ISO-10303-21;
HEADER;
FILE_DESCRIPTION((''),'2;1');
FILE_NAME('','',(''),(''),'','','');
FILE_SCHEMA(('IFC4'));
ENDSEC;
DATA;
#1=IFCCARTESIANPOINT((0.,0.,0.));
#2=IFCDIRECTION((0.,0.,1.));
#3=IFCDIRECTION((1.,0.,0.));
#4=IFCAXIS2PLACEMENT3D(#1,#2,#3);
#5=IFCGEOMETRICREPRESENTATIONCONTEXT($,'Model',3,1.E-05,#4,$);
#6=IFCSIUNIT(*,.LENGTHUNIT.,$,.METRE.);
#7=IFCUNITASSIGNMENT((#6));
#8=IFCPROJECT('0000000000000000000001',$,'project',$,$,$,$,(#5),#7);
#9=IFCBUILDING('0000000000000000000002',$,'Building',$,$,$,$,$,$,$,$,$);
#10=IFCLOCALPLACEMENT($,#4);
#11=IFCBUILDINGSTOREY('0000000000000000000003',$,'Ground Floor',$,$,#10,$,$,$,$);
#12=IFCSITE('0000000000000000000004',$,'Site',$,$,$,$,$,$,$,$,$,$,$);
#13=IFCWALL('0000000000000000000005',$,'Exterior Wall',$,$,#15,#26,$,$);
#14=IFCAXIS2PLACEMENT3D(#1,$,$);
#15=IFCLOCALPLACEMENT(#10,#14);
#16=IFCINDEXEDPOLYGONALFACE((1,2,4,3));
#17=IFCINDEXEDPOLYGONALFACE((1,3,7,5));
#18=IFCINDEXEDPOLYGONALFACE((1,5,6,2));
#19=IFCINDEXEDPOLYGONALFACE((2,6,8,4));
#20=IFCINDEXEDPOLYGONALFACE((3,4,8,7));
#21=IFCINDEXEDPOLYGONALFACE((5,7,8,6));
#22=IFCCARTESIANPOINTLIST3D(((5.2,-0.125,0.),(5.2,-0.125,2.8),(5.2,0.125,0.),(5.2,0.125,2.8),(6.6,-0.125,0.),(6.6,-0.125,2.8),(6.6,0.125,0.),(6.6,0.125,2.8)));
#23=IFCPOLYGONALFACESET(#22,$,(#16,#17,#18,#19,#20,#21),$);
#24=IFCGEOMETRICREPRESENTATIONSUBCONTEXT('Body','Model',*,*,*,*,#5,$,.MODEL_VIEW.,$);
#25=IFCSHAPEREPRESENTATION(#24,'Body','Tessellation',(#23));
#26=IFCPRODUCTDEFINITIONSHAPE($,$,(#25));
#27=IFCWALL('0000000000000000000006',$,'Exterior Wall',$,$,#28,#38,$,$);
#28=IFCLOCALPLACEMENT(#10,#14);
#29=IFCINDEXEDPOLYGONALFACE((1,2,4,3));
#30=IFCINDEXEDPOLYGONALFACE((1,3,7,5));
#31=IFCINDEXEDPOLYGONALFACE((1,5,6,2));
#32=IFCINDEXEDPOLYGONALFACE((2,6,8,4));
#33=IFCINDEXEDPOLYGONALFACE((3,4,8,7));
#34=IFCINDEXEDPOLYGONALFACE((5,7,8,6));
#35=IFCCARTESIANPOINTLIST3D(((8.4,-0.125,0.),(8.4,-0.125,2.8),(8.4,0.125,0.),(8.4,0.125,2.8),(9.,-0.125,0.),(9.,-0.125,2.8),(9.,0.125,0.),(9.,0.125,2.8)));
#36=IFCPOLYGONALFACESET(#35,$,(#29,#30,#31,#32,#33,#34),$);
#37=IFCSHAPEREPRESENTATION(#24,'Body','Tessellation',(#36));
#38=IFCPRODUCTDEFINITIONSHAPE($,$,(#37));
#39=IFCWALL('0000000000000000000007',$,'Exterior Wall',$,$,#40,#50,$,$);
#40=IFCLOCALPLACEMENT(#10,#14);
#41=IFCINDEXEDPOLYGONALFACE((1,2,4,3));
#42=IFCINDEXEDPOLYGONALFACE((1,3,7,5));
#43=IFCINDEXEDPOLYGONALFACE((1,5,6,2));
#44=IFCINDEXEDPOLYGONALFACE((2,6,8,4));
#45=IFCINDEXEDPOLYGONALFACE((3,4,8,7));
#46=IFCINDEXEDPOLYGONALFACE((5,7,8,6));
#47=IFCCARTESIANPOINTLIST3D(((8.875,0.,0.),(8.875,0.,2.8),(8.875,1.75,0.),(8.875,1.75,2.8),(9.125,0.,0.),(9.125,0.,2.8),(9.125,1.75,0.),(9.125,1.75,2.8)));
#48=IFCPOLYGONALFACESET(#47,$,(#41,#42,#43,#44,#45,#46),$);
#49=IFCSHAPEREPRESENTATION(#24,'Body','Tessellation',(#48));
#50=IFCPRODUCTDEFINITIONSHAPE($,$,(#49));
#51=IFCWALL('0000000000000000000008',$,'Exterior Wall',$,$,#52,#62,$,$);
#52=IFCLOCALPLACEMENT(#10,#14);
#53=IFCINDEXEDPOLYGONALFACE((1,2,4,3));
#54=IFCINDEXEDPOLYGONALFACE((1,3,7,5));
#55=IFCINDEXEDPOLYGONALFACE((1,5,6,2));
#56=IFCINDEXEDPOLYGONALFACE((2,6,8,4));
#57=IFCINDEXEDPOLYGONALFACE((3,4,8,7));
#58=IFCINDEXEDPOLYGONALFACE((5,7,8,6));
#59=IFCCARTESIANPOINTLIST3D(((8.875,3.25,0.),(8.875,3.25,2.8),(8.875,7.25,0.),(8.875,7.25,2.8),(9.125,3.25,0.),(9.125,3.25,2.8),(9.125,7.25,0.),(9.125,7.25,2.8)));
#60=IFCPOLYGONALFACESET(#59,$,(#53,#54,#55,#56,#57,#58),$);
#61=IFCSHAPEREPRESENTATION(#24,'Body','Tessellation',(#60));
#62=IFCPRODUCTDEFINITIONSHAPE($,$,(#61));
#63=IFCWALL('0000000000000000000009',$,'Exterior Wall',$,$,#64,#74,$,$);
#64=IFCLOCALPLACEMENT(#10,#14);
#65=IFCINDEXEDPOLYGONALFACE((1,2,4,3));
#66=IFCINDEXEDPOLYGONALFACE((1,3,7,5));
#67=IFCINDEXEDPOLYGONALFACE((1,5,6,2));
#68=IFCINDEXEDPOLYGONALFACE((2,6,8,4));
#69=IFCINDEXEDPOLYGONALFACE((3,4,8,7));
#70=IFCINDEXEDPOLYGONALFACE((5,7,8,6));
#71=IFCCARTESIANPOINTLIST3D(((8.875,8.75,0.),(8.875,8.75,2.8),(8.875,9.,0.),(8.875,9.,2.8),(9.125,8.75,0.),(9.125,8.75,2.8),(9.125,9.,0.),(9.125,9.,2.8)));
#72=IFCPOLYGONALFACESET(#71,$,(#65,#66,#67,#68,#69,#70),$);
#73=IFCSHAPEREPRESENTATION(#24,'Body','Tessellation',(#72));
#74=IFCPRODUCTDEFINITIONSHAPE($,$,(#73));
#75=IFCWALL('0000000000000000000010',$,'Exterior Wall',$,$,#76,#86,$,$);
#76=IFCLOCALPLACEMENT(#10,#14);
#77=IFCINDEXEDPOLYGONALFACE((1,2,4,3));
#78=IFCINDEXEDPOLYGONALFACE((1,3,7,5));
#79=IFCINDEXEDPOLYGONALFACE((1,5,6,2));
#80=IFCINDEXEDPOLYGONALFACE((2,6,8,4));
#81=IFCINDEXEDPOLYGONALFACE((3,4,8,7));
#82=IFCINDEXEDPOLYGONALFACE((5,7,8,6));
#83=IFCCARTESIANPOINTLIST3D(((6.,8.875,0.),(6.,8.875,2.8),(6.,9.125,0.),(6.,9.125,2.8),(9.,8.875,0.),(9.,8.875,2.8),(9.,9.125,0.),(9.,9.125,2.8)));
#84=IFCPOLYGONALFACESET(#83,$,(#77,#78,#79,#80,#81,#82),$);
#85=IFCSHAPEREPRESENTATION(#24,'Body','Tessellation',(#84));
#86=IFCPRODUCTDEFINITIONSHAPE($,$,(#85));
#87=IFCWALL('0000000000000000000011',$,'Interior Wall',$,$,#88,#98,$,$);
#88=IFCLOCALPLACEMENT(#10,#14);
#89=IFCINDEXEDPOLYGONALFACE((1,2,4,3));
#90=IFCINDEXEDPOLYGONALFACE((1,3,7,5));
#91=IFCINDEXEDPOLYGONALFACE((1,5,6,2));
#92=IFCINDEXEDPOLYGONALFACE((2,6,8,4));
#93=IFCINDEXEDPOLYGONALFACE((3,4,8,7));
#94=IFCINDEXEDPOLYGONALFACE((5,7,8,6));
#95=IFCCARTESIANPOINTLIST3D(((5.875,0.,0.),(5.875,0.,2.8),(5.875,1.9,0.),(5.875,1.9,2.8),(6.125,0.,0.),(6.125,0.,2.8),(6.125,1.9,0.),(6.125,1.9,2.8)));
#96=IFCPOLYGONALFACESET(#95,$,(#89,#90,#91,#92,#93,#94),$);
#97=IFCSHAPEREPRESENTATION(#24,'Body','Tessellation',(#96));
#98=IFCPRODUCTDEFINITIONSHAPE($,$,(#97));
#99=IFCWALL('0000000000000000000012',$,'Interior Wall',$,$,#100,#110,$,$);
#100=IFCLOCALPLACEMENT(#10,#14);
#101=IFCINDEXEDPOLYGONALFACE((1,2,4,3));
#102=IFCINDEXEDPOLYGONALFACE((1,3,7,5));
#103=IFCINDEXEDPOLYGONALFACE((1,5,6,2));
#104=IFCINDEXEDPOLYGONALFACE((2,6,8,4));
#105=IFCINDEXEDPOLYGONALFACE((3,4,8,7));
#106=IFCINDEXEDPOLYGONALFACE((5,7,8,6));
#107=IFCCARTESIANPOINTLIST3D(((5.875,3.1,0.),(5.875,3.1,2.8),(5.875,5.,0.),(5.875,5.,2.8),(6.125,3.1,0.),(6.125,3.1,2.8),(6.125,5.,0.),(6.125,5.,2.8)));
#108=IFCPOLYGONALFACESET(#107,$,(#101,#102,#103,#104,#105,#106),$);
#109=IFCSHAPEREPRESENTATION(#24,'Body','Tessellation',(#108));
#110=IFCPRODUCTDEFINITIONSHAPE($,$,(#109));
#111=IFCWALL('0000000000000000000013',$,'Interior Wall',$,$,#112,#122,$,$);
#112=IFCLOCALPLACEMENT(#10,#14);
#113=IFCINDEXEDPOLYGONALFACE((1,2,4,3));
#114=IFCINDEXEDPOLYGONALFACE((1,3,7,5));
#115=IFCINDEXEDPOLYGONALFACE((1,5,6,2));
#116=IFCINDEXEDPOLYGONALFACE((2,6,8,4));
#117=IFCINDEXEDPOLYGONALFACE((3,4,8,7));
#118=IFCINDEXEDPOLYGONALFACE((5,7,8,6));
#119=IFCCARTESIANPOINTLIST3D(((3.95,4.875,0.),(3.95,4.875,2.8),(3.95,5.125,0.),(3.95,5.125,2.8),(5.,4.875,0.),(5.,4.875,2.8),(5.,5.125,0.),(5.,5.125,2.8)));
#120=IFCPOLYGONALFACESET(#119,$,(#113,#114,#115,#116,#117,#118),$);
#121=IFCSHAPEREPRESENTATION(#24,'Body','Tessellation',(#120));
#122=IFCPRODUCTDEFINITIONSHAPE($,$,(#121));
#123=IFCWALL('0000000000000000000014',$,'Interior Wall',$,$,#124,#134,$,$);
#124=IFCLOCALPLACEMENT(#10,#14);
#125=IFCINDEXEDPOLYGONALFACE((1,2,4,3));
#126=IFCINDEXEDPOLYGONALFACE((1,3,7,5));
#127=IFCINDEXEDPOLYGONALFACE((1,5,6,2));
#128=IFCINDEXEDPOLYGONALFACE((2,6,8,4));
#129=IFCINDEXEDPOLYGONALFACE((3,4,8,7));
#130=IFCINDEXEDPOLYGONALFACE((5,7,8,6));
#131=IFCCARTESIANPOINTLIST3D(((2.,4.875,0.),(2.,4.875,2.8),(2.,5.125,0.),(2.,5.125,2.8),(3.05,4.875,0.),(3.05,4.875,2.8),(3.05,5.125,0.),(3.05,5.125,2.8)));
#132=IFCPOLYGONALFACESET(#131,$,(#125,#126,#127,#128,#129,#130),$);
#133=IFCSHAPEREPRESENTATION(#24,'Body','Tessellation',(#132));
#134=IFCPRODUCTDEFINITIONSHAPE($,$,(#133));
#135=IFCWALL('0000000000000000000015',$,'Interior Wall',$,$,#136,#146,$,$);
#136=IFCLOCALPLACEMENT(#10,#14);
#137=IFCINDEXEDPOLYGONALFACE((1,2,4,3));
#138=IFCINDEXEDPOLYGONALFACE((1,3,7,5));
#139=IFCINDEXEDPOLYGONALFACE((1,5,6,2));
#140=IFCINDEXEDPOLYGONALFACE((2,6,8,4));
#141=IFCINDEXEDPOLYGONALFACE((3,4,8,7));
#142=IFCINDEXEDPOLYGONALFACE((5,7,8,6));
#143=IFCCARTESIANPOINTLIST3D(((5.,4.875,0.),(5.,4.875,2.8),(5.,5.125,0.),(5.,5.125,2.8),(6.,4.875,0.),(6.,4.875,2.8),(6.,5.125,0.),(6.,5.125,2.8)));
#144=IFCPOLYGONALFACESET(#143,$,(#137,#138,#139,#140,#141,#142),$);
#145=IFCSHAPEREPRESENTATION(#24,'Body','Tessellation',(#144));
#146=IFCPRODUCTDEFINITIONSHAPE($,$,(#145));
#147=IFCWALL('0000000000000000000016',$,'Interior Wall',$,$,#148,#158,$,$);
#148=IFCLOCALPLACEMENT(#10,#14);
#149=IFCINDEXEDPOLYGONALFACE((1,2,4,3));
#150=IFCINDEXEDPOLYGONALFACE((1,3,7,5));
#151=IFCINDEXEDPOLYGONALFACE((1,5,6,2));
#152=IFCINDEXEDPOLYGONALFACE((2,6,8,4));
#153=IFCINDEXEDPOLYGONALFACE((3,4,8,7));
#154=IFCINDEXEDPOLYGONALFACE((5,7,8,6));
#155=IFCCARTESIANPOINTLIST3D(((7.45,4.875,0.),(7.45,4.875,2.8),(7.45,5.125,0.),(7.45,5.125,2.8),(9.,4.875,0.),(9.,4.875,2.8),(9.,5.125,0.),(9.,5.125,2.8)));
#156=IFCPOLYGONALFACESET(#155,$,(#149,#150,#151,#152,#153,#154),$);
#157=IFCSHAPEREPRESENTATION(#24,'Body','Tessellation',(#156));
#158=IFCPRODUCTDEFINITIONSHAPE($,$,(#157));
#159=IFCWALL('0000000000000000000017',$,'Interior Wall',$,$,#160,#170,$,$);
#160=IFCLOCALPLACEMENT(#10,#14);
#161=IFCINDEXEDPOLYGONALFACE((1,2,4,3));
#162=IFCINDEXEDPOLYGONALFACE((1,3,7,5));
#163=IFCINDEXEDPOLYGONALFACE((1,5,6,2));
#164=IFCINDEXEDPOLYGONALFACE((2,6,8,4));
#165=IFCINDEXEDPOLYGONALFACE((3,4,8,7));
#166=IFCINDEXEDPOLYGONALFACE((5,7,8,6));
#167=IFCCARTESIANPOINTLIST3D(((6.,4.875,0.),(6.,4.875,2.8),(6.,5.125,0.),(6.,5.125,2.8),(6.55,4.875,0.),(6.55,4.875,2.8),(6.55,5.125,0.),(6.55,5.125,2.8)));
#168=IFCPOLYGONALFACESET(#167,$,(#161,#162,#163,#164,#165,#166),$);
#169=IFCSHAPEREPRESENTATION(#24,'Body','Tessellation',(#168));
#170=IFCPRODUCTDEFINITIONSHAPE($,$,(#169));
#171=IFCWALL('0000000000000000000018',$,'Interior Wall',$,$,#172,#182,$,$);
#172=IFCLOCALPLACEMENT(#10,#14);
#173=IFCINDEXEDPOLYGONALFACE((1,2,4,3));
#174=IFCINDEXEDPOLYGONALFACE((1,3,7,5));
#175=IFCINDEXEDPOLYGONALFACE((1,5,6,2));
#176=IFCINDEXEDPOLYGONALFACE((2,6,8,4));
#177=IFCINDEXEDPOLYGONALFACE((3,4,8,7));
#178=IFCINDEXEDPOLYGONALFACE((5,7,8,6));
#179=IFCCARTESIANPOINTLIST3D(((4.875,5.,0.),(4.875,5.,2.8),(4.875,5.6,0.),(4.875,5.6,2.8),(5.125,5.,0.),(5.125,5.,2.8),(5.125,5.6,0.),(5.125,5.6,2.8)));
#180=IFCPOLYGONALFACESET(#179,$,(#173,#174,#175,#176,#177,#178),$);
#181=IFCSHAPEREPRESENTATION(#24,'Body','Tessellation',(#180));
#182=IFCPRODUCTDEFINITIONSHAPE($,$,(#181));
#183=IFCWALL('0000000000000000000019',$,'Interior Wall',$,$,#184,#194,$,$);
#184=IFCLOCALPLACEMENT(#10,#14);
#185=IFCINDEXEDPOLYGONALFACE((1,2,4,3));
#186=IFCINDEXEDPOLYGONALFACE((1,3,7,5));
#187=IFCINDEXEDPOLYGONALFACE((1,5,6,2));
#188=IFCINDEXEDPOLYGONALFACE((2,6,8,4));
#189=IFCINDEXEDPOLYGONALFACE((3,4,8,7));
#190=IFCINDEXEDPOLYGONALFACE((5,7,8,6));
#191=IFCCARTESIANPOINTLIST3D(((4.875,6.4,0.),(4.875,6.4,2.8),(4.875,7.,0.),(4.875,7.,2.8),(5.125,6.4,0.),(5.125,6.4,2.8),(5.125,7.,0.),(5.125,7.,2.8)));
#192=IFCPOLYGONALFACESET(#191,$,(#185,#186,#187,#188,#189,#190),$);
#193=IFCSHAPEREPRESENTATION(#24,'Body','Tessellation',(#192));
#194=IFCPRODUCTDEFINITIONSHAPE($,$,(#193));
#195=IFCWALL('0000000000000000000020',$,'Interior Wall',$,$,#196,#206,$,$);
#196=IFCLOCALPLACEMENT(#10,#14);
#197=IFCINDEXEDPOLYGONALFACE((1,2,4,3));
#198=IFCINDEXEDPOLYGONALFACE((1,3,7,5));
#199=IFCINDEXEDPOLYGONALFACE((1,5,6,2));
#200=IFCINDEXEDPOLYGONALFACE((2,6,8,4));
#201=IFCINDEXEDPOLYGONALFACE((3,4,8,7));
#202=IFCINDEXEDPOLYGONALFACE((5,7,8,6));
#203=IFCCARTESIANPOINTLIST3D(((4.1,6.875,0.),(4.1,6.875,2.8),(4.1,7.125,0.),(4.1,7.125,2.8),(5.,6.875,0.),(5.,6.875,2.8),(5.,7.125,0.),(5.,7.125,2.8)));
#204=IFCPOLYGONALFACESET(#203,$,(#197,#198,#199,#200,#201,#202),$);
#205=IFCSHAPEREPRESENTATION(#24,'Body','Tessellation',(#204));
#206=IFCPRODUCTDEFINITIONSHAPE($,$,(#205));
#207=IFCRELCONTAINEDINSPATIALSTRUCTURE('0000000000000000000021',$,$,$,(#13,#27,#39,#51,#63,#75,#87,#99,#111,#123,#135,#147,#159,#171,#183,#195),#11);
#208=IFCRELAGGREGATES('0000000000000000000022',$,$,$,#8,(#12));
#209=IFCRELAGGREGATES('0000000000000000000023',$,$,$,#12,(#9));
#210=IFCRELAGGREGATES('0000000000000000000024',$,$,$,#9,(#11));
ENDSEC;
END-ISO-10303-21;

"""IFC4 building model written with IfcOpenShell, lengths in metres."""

from ifc_helpers import new_model, si_unit, frame, origin_with_axes, place, context, subcontext, project, spatial, indexed_curve, outline, extrude, element, save


model = new_model("IFC4")

# Units and contexts
model_context = context("Model", 3, precision=1e-05, world=origin_with_axes())
body_context = subcontext(model_context, "Body", "Model", "MODEL_VIEW")
ifc_project = project(units=[si_unit("LENGTHUNIT", "METRE")], contexts=[model_context])

# Site, building, storey
site = spatial("IfcSite", under=ifc_project, Name="Site")
building = spatial("IfcBuilding", under=site, Name="Building")
storey_placement = place(None, origin_with_axes())
storey = spatial("IfcBuildingStorey", under=building, at=storey_placement, Name="Ground Floor")

# Walls
wall_1_placement = place(storey_placement, frame((5.2, 0.0, 0.0), z_axis=(0.0, 0.0, 1.0), x_axis=(1.0, 0.0, 0.0)))
element("IfcWall", 1, at=wall_1_placement, inside=storey, Name="Exterior Wall", context=body_context, shape_type="SweptSolid", body=[
    extrude(outline(indexed_curve([(0.0, 0.0), (0.0, 0.25), (1.4, 0.25), (1.4, 0.0), (0.0, 0.0)], self_intersect=False)), frame((0.0, -0.125, 0.0), z_axis=(0.0, 0.0, 1.0), x_axis=(1.0, 0.0, 0.0)), (0.0, 0.0, 1.0), 2.8),
])
wall_2_placement = place(storey_placement, frame((8.4, 0.0, 0.0), z_axis=(0.0, 0.0, 1.0), x_axis=(1.0, 0.0, 0.0)))
element("IfcWall", 2, at=wall_2_placement, inside=storey, Name="Exterior Wall", context=body_context, shape_type="SweptSolid", body=[
    extrude(outline(indexed_curve([(0.0, 0.0), (0.0, 0.25), (0.6, 0.25), (0.6, 0.0), (0.0, 0.0)], self_intersect=False)), frame((0.0, -0.125, 0.0), z_axis=(0.0, 0.0, 1.0), x_axis=(1.0, 0.0, 0.0)), (0.0, 0.0, 1.0), 2.8),
])
wall_3_placement = place(storey_placement, frame((9.0, 0.0, 0.0), z_axis=(0.0, 0.0, 1.0), x_axis=(0.0, 1.0, 0.0)))
element("IfcWall", 3, at=wall_3_placement, inside=storey, Name="Exterior Wall", context=body_context, shape_type="SweptSolid", body=[
    extrude(outline(indexed_curve([(0.0, 0.0), (0.0, 0.25), (1.75, 0.25), (1.75, 0.0), (0.0, 0.0)], self_intersect=False)), frame((0.0, -0.125, 0.0), z_axis=(0.0, 0.0, 1.0), x_axis=(1.0, 0.0, 0.0)), (0.0, 0.0, 1.0), 2.8),
])
wall_4_placement = place(storey_placement, frame((9.0, 3.25, 0.0), z_axis=(0.0, 0.0, 1.0), x_axis=(0.0, 1.0, 0.0)))
element("IfcWall", 4, at=wall_4_placement, inside=storey, Name="Exterior Wall", context=body_context, shape_type="SweptSolid", body=[
    extrude(outline(indexed_curve([(0.0, 0.0), (0.0, 0.25), (4.0, 0.25), (4.0, 0.0), (0.0, 0.0)], self_intersect=False)), frame((0.0, -0.125, 0.0), z_axis=(0.0, 0.0, 1.0), x_axis=(1.0, 0.0, 0.0)), (0.0, 0.0, 1.0), 2.8),
])
wall_5_placement = place(storey_placement, frame((9.0, 8.75, 0.0), z_axis=(0.0, 0.0, 1.0), x_axis=(0.0, 1.0, 0.0)))
element("IfcWall", 5, at=wall_5_placement, inside=storey, Name="Exterior Wall", context=body_context, shape_type="SweptSolid", body=[
    extrude(outline(indexed_curve([(0.0, 0.0), (0.0, 0.25), (0.25, 0.25), (0.25, 0.0), (0.0, 0.0)], self_intersect=False)), frame((0.0, -0.125, 0.0), z_axis=(0.0, 0.0, 1.0), x_axis=(1.0, 0.0, 0.0)), (0.0, 0.0, 1.0), 2.8),
])
wall_6_placement = place(storey_placement, frame((9.0, 9.0, 0.0), z_axis=(0.0, 0.0, 1.0), x_axis=(-1.0, 0.0, 0.0)))
element("IfcWall", 6, at=wall_6_placement, inside=storey, Name="Exterior Wall", context=body_context, shape_type="SweptSolid", body=[
    extrude(outline(indexed_curve([(0.0, 0.0), (0.0, 0.25), (3.0, 0.25), (3.0, 0.0), (0.0, 0.0)], self_intersect=False)), frame((0.0, -0.125, 0.0), z_axis=(0.0, 0.0, 1.0), x_axis=(1.0, 0.0, 0.0)), (0.0, 0.0, 1.0), 2.8),
])
for number, where, z_axis, x_axis, name in (
    (7, (6.0, 0.0, 0.0), (0.0, 0.0, 1.0), (0.0, 1.0, 0.0), "Interior Wall"),
    (8, (6.0, 3.1, 0.0), (0.0, 0.0, 1.0), (0.0, 1.0, 0.0), "Interior Wall"),
):
    element("IfcWall", number, at=place(storey_placement, frame(where, z_axis=z_axis, x_axis=x_axis)), inside=storey, Name=name, context=body_context, shape_type="SweptSolid", body=[
        extrude(outline(indexed_curve([(0.0, 0.0), (0.0, 0.25), (1.9, 0.25), (1.9, 0.0), (0.0, 0.0)], self_intersect=False)), frame((0.0, -0.125, 0.0), z_axis=(0.0, 0.0, 1.0), x_axis=(1.0, 0.0, 0.0)), (0.0, 0.0, 1.0), 2.8),
    ])
for number, where, z_axis, x_axis, name in (
    (9, (5.0, 5.0, 0.0), (0.0, 0.0, 1.0), (-1.0, 0.0, 0.0), "Interior Wall"),
    (10, (3.05, 5.0, 0.0), (0.0, 0.0, 1.0), (-1.0, 0.0, 0.0), "Interior Wall"),
):
    element("IfcWall", number, at=place(storey_placement, frame(where, z_axis=z_axis, x_axis=x_axis)), inside=storey, Name=name, context=body_context, shape_type="SweptSolid", body=[
        extrude(outline(indexed_curve([(0.0, 0.0), (0.0, 0.25), (1.05, 0.25), (1.05, 0.0), (0.0, 0.0)], self_intersect=False)), frame((0.0, -0.125, 0.0), z_axis=(0.0, 0.0, 1.0), x_axis=(1.0, 0.0, 0.0)), (0.0, 0.0, 1.0), 2.8),
    ])
wall_7_placement = place(storey_placement, frame((6.0, 5.0, 0.0), z_axis=(0.0, 0.0, 1.0), x_axis=(-1.0, 0.0, 0.0)))
element("IfcWall", 11, at=wall_7_placement, inside=storey, Name="Interior Wall", context=body_context, shape_type="SweptSolid", body=[
    extrude(outline(indexed_curve([(0.0, 0.0), (0.0, 0.25), (1.0, 0.25), (1.0, 0.0), (0.0, 0.0)], self_intersect=False)), frame((0.0, -0.125, 0.0), z_axis=(0.0, 0.0, 1.0), x_axis=(1.0, 0.0, 0.0)), (0.0, 0.0, 1.0), 2.8),
])
wall_8_placement = place(storey_placement, frame((9.0, 5.0, 0.0), z_axis=(0.0, 0.0, 1.0), x_axis=(-1.0, 0.0, 0.0)))
element("IfcWall", 12, at=wall_8_placement, inside=storey, Name="Interior Wall", context=body_context, shape_type="SweptSolid", body=[
    extrude(outline(indexed_curve([(0.0, 0.0), (0.0, 0.25), (1.55, 0.25), (1.55, 0.0), (0.0, 0.0)], self_intersect=False)), frame((0.0, -0.125, 0.0), z_axis=(0.0, 0.0, 1.0), x_axis=(1.0, 0.0, 0.0)), (0.0, 0.0, 1.0), 2.8),
])
wall_9_placement = place(storey_placement, frame((6.55, 5.0, 0.0), z_axis=(0.0, 0.0, 1.0), x_axis=(-1.0, 0.0, 0.0)))
element("IfcWall", 13, at=wall_9_placement, inside=storey, Name="Interior Wall", context=body_context, shape_type="SweptSolid", body=[
    extrude(outline(indexed_curve([(0.0, 0.0), (0.0, 0.25), (0.55, 0.25), (0.55, 0.0), (0.0, 0.0)], self_intersect=False)), frame((0.0, -0.125, 0.0), z_axis=(0.0, 0.0, 1.0), x_axis=(1.0, 0.0, 0.0)), (0.0, 0.0, 1.0), 2.8),
])
for number, where, z_axis, x_axis, name in (
    (14, (5.0, 5.0, 0.0), (0.0, 0.0, 1.0), (0.0, 1.0, 0.0), "Interior Wall"),
    (15, (5.0, 6.4, 0.0), (0.0, 0.0, 1.0), (0.0, 1.0, 0.0), "Interior Wall"),
):
    element("IfcWall", number, at=place(storey_placement, frame(where, z_axis=z_axis, x_axis=x_axis)), inside=storey, Name=name, context=body_context, shape_type="SweptSolid", body=[
        extrude(outline(indexed_curve([(0.0, 0.0), (0.0, 0.25), (0.6, 0.25), (0.6, 0.0), (0.0, 0.0)], self_intersect=False)), frame((0.0, -0.125, 0.0), z_axis=(0.0, 0.0, 1.0), x_axis=(1.0, 0.0, 0.0)), (0.0, 0.0, 1.0), 2.8),
    ])
wall_10_placement = place(storey_placement, frame((5.0, 7.0, 0.0), z_axis=(0.0, 0.0, 1.0), x_axis=(-1.0, 0.0, 0.0)))
element("IfcWall", 16, at=wall_10_placement, inside=storey, Name="Interior Wall", context=body_context, shape_type="SweptSolid", body=[
    extrude(outline(indexed_curve([(0.0, 0.0), (0.0, 0.25), (0.9, 0.25), (0.9, 0.0), (0.0, 0.0)], self_intersect=False)), frame((0.0, -0.125, 0.0), z_axis=(0.0, 0.0, 1.0), x_axis=(1.0, 0.0, 0.0)), (0.0, 0.0, 1.0), 2.8),
])

save(model, "model.ifc")
